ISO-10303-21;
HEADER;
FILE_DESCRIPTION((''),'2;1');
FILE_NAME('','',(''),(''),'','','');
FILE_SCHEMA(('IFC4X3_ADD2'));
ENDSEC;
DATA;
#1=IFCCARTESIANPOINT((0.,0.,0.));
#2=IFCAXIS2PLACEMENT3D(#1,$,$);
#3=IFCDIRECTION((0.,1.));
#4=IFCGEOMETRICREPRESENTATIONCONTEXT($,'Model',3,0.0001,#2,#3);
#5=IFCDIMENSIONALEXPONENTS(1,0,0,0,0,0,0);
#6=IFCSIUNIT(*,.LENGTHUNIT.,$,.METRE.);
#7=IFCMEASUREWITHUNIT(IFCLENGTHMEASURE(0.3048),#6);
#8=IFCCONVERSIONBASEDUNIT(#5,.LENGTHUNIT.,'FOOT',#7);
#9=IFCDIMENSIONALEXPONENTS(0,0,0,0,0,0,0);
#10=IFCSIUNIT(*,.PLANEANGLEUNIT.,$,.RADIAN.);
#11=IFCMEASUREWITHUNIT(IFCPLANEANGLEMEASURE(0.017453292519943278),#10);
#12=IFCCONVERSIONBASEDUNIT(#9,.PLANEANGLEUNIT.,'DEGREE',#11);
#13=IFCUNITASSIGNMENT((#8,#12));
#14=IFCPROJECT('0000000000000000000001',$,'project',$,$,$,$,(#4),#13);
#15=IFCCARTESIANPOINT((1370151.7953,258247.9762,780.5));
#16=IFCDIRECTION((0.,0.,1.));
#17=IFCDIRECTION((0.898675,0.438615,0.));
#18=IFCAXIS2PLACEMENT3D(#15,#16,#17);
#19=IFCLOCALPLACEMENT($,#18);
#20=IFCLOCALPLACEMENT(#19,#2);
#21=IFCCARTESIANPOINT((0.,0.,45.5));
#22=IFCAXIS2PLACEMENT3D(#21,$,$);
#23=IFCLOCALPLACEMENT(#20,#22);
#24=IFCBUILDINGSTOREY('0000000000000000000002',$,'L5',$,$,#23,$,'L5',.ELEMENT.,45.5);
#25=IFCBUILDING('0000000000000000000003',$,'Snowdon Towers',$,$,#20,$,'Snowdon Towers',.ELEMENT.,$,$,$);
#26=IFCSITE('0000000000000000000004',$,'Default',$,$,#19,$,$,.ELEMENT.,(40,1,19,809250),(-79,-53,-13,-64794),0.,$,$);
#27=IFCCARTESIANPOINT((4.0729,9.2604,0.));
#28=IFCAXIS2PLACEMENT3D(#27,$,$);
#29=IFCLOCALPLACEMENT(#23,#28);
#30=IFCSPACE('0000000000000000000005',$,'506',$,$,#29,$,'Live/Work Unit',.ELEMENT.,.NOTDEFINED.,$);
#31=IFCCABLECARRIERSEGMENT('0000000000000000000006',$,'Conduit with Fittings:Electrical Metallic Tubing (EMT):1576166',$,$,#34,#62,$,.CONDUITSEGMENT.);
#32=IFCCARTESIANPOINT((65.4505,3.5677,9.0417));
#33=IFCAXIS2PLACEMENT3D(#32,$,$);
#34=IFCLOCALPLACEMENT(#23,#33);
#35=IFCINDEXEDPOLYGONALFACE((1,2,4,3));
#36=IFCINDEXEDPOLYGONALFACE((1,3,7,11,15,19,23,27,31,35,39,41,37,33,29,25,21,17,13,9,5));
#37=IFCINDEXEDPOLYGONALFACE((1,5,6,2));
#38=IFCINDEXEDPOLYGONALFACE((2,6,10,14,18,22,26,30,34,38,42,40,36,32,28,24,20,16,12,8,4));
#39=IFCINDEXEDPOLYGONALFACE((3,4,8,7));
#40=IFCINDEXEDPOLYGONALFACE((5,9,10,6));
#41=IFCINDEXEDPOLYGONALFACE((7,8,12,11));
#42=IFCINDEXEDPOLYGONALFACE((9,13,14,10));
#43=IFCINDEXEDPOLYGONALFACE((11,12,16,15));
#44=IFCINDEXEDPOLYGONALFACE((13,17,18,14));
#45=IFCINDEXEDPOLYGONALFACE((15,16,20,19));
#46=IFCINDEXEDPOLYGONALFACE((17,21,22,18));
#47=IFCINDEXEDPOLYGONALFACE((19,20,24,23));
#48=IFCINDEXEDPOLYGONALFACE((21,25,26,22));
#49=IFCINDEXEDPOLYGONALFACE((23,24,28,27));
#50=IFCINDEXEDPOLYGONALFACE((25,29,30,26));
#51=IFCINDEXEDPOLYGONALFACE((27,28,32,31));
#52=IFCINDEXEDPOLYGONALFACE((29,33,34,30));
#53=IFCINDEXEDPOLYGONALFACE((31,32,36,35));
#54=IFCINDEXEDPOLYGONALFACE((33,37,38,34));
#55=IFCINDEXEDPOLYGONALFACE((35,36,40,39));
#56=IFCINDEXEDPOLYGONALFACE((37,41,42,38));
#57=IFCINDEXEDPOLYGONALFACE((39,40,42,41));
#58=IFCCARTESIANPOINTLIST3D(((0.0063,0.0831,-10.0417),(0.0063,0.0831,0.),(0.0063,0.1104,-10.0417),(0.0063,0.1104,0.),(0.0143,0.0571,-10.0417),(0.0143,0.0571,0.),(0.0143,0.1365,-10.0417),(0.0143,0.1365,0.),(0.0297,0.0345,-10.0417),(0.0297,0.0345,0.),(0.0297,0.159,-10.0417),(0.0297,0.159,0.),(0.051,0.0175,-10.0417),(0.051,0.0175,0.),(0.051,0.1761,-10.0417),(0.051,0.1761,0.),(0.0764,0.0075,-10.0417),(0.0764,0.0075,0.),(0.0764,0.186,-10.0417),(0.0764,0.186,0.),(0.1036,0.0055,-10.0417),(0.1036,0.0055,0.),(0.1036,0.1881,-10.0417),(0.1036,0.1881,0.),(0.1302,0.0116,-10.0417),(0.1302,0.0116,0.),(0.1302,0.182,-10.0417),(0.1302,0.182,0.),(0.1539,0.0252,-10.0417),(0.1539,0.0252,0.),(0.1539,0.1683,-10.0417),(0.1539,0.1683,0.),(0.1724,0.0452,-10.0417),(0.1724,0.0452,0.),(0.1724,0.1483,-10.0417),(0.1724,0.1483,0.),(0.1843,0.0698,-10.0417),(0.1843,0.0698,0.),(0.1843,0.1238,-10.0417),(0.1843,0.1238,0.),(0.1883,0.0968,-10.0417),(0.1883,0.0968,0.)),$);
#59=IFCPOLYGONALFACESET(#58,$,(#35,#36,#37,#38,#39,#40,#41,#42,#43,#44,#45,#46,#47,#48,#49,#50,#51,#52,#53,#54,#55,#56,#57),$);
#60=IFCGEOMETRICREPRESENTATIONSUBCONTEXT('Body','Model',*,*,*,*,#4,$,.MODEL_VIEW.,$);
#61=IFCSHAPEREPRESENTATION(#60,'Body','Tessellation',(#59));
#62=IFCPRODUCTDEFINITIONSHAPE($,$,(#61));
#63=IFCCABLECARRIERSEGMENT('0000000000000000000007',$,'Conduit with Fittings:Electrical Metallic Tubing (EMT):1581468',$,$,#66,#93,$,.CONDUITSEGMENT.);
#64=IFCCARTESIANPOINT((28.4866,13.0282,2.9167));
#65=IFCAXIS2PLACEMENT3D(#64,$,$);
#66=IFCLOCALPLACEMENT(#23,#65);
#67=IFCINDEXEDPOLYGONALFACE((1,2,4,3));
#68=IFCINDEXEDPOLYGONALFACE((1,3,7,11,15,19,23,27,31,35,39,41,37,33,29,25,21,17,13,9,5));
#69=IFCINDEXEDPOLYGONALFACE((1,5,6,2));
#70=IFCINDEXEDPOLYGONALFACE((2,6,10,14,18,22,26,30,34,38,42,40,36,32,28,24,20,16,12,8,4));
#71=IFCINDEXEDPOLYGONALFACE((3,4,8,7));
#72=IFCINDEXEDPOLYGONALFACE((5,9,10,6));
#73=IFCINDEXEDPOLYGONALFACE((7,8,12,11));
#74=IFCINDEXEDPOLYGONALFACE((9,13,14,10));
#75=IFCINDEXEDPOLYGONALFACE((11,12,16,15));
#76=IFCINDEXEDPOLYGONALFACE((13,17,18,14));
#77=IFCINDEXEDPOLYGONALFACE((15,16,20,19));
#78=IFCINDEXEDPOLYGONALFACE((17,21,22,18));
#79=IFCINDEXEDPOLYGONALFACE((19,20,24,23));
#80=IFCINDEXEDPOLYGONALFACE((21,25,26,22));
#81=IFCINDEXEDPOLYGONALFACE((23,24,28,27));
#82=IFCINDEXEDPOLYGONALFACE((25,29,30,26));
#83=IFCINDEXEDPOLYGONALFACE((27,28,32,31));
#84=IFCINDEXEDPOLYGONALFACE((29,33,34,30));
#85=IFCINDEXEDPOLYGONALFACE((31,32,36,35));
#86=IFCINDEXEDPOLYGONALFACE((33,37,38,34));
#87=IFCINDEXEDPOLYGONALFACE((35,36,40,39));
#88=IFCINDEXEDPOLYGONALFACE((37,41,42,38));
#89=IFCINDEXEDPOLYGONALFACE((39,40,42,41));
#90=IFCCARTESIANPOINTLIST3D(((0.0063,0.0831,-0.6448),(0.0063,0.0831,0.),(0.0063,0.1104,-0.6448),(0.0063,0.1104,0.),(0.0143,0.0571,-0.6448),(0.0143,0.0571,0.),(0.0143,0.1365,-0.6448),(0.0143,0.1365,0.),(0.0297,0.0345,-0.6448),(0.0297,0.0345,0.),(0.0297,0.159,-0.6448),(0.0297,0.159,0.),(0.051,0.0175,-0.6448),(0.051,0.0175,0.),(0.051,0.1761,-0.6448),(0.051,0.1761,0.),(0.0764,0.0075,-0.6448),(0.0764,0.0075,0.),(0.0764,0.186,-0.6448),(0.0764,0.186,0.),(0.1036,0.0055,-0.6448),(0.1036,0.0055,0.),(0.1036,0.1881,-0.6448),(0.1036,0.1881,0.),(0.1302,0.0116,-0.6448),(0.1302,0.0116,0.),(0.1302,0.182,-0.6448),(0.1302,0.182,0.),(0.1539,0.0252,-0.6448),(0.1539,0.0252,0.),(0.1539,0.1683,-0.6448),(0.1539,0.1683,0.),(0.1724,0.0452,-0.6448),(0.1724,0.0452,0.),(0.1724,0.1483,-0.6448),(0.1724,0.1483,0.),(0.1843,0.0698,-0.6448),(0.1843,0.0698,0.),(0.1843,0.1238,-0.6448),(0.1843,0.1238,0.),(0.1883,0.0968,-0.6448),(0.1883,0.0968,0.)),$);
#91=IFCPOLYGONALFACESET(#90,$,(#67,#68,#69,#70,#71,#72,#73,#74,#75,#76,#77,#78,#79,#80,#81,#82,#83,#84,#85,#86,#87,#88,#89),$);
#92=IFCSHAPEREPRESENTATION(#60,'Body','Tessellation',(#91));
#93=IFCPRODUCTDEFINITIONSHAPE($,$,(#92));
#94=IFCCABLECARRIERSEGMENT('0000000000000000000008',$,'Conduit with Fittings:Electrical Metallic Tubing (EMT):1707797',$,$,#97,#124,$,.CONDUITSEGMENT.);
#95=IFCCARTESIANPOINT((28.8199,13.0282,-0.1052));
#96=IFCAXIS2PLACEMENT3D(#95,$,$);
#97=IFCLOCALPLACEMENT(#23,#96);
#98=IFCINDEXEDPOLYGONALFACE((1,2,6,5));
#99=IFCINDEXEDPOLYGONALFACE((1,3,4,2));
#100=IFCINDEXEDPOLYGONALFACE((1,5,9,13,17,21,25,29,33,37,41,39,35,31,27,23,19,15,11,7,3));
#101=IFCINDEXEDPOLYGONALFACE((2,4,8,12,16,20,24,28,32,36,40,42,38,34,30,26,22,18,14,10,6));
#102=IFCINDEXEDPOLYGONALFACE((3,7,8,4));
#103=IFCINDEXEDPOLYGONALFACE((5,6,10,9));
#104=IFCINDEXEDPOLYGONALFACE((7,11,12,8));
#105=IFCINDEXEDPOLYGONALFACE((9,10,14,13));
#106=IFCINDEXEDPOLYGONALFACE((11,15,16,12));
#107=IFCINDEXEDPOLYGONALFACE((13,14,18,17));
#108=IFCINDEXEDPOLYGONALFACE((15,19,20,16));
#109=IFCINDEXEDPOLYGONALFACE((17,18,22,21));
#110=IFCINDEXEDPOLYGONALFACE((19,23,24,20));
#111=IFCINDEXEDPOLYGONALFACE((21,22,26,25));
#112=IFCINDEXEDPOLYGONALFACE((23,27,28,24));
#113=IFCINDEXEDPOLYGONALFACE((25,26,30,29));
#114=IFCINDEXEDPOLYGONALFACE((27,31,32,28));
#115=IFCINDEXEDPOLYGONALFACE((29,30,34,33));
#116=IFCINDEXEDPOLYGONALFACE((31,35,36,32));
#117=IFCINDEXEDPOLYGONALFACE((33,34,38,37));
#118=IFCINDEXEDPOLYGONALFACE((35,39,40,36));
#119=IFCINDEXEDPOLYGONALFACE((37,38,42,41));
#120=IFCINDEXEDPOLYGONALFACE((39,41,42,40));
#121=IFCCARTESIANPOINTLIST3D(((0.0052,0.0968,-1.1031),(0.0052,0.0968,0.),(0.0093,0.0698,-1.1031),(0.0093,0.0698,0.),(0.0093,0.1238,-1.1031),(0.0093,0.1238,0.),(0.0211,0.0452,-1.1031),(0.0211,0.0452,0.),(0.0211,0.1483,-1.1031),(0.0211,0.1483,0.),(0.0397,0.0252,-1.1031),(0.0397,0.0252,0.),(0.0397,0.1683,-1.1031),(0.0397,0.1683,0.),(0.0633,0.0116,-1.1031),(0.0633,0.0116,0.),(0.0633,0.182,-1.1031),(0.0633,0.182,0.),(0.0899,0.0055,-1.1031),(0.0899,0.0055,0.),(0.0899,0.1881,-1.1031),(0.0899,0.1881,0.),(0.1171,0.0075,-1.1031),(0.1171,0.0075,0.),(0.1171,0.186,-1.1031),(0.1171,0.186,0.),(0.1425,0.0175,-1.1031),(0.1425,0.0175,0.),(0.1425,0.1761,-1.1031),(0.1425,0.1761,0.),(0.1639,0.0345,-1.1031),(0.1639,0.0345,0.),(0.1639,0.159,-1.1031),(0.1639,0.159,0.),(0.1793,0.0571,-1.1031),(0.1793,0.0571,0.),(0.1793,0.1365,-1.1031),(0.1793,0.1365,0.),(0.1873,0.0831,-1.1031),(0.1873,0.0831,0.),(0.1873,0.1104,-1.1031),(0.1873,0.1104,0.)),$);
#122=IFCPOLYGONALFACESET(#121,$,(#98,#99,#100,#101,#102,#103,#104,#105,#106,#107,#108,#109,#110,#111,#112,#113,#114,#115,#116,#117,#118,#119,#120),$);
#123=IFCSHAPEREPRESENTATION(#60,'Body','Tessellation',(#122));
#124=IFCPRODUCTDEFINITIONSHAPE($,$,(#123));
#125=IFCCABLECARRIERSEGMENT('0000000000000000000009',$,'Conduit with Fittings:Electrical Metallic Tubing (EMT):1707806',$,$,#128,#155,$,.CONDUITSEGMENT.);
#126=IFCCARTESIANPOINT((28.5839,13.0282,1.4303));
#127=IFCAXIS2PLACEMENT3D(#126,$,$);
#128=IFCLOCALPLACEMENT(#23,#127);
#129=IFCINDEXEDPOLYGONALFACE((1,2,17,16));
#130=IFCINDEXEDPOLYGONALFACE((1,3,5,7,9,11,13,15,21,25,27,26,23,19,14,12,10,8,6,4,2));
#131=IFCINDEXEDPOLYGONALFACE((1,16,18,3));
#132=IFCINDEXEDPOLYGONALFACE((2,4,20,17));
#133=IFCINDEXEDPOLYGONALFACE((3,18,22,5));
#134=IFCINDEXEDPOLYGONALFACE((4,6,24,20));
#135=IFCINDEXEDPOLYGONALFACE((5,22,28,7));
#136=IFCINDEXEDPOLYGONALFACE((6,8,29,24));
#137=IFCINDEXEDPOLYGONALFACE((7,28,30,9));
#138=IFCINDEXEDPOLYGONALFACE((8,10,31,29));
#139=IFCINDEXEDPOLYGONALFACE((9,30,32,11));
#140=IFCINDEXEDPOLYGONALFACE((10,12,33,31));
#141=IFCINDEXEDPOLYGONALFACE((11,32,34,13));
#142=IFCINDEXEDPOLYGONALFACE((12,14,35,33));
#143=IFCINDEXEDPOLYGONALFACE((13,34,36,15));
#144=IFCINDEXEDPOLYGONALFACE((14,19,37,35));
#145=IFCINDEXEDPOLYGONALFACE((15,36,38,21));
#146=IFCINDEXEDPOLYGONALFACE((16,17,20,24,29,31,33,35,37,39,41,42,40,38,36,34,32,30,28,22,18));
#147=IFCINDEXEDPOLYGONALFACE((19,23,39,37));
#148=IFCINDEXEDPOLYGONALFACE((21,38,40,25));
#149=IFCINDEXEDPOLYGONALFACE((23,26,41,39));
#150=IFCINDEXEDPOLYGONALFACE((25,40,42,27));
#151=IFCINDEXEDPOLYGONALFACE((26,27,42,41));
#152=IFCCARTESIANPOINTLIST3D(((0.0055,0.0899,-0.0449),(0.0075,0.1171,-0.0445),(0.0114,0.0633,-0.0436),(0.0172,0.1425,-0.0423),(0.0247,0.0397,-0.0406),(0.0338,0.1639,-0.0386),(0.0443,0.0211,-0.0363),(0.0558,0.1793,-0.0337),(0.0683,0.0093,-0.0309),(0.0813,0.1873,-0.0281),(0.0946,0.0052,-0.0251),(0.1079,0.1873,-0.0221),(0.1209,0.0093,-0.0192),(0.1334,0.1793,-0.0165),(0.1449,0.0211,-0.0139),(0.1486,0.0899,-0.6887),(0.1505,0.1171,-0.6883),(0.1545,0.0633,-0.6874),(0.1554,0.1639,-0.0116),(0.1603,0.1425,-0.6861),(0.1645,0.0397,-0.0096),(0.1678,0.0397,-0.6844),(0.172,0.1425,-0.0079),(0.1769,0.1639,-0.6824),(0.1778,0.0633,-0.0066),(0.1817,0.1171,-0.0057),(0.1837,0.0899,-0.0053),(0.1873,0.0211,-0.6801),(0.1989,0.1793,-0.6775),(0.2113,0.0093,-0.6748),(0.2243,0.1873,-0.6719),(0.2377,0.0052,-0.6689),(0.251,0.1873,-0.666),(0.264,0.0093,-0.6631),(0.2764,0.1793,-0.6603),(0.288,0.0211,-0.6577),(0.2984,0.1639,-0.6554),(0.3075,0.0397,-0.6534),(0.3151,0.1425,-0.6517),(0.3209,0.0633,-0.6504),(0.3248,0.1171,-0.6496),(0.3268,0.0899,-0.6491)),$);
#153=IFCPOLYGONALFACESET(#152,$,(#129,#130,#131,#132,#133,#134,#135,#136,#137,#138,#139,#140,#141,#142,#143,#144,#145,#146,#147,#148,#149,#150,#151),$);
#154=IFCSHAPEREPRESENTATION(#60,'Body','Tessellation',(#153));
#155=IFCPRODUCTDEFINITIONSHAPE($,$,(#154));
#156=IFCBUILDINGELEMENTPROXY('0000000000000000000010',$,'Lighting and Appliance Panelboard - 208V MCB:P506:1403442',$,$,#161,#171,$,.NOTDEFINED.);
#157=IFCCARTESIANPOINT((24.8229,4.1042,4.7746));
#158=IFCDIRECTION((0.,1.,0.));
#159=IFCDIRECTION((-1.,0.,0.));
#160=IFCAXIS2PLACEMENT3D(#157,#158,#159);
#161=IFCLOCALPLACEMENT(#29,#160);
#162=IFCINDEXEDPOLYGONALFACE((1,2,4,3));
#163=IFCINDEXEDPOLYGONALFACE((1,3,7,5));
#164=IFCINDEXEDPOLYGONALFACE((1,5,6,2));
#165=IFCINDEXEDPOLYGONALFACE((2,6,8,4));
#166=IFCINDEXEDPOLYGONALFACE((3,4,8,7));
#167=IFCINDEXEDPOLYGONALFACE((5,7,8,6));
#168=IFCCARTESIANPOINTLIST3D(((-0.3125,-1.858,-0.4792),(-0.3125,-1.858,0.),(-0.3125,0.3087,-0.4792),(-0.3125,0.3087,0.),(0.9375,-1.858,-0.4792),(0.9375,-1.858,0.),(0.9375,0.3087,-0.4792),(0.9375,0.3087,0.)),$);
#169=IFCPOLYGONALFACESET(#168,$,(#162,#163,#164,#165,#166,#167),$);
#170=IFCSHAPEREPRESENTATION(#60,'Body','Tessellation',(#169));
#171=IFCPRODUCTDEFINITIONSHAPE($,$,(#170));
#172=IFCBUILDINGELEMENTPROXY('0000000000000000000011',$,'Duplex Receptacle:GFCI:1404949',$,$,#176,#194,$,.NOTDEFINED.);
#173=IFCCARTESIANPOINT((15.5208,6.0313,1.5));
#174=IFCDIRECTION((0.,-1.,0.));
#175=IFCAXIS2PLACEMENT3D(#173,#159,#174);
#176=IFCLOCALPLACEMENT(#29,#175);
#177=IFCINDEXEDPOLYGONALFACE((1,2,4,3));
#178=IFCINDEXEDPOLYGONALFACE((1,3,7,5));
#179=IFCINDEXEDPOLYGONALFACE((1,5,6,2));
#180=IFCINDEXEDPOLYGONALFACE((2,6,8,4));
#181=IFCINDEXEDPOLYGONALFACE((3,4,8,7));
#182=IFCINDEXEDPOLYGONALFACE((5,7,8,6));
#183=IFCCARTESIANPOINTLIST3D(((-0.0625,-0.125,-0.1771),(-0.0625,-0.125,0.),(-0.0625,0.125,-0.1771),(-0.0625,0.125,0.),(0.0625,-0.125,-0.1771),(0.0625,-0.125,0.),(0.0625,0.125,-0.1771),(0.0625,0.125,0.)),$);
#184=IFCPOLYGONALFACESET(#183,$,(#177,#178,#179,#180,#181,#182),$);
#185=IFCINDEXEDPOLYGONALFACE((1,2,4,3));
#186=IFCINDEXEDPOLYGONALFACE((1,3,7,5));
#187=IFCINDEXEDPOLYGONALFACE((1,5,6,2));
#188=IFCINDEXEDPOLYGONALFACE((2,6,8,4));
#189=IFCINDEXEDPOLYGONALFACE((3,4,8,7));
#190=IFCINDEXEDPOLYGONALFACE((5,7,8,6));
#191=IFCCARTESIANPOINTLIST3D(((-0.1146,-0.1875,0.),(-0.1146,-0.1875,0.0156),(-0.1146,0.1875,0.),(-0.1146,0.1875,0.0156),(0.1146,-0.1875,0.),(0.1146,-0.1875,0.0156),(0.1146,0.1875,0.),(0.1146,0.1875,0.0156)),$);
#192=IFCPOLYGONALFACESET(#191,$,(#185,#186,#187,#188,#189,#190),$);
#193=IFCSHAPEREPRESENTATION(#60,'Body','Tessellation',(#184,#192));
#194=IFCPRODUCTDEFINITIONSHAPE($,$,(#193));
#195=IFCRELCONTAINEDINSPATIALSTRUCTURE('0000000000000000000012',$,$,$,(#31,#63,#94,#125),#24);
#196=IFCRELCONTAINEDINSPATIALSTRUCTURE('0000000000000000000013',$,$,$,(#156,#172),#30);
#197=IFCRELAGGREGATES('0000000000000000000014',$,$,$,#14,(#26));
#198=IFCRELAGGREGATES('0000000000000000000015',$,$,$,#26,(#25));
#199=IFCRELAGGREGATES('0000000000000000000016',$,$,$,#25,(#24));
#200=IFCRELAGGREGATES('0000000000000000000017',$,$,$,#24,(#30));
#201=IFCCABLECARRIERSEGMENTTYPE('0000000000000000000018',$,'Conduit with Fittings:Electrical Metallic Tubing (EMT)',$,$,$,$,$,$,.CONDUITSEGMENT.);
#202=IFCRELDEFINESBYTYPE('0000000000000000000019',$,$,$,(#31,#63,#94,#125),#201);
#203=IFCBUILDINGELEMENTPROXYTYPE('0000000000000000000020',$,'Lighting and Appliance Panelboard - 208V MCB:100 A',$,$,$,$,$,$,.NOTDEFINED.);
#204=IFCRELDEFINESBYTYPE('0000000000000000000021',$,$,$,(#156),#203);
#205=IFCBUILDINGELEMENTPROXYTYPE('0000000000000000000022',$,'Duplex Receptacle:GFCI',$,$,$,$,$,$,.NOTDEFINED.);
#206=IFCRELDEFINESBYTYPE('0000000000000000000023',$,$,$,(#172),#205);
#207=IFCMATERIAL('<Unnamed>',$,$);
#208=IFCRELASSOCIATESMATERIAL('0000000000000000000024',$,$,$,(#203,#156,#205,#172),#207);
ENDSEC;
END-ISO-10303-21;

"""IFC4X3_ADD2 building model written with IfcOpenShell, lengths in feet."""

from ifc_helpers import new_model, entity, si_unit, converted_unit, direction, frame, frame_2d, origin, origin_2d_with_axis, place, context, subcontext, project, spatial, rectangle, circle, extrude, source, transform, mapped, material, type_object, type_shapes, element, save


model = new_model("IFC4X3_ADD2")

# Units and contexts
model_context = context("Model", 3, precision=0.0001, world=origin(), true_north=direction((0.0, 1.0)))
body_context = subcontext(model_context, "Body", "Model", "MODEL_VIEW")
ifc_project = project(units=[converted_unit("LENGTHUNIT", "FOOT", entity("IfcLengthMeasure", 0.3048), si_unit("LENGTHUNIT", "METRE"), dimensions=[1, 0, 0, 0, 0, 0, 0]), converted_unit("PLANEANGLEUNIT", "DEGREE", entity("IfcPlaneAngleMeasure", 0.017453292519943278), si_unit("PLANEANGLEUNIT", "RADIAN"), dimensions=[0, 0, 0, 0, 0, 0, 0])], contexts=[model_context])

# Site, building, storey, space
site_placement = place(None, frame((1370151.7953, 258247.9762, 780.5), z_axis=(0.0, 0.0, 1.0), x_axis=(0.898675, 0.438615, 0.0)))
site = spatial("IfcSite", under=ifc_project, at=site_placement, Name="Default", CompositionType="ELEMENT", RefLatitude=(40, 1, 19, 809250), RefLongitude=(-79, -53, -13, -64794), RefElevation=0.0)
building_placement = place(site_placement, origin())
building = spatial("IfcBuilding", under=site, at=building_placement, Name="Snowdon Towers", LongName="Snowdon Towers", CompositionType="ELEMENT")
storey_placement = place(building_placement, frame((0.0, 0.0, 45.5)))
storey = spatial("IfcBuildingStorey", under=building, at=storey_placement, Name="L5", LongName="L5", CompositionType="ELEMENT", Elevation=45.5)
space_1_placement = place(storey_placement, frame((4.0729, 9.2604, 0.0)))
space_1 = spatial("IfcSpace", under=storey, at=space_1_placement, Name="506", LongName="Live/Work Unit", CompositionType="ELEMENT", PredefinedType="NOTDEFINED")

# Shared definitions
ifc_material_1 = material(Name="<Unnamed>")

# Cable carrier segments
cable_carrier_segment_type = type_object("IfcCableCarrierSegmentType", Name="Conduit with Fittings:Electrical Metallic Tubing (EMT)", PredefinedType="CONDUITSEGMENT")
cable_carrier_segment_1_placement = place(storey_placement, frame((65.4505, 3.5677, 9.0417)))
element("IfcCableCarrierSegment", 1, at=cable_carrier_segment_1_placement, inside=storey, type_object=cable_carrier_segment_type, Name="Conduit with Fittings:Electrical Metallic Tubing (EMT):1576166", PredefinedType="CONDUITSEGMENT", context=body_context, shape_type="SweptSolid", body=[
    extrude(circle(Radius=0.0915, at=frame_2d((0.0, 0.0), x_axis=(1.0, 0.0))), frame((0.0968, 0.0968, -10.0417)), (0.0, 0.0, 1.0), 10.0417),
])
cable_carrier_segment_2_placement = place(storey_placement, frame((28.4866, 13.0282, 2.9167)))
element("IfcCableCarrierSegment", 2, at=cable_carrier_segment_2_placement, inside=storey, type_object=cable_carrier_segment_type, Name="Conduit with Fittings:Electrical Metallic Tubing (EMT):1581468", PredefinedType="CONDUITSEGMENT", context=body_context, shape_type="SweptSolid", body=[
    extrude(circle(Radius=0.0915, at=frame_2d((0.0, 0.0), x_axis=(1.0, 0.0))), frame((0.0968, 0.0968, -0.6448)), (0.0, 0.0, 1.0), 0.6448),
])
cable_carrier_segment_3_placement = place(storey_placement, frame((28.8199, 13.0282, -0.1052)))
element("IfcCableCarrierSegment", 3, at=cable_carrier_segment_3_placement, inside=storey, type_object=cable_carrier_segment_type, Name="Conduit with Fittings:Electrical Metallic Tubing (EMT):1707797", PredefinedType="CONDUITSEGMENT", context=body_context, shape_type="SweptSolid", body=[
    extrude(circle(Radius=0.0915, at=frame_2d((0.0, 0.0), x_axis=(1.0, 0.0))), frame((0.0968, 0.0968, -1.1031), z_axis=(0.0, 0.0, 1.0), x_axis=(-1.0, 0.0, 0.0)), (0.0, 0.0, 1.0), 1.1031),
])
cable_carrier_segment_4_placement = place(storey_placement, frame((28.5839, 13.0282, 1.4303)))
element("IfcCableCarrierSegment", 4, at=cable_carrier_segment_4_placement, inside=storey, type_object=cable_carrier_segment_type, Name="Conduit with Fittings:Electrical Metallic Tubing (EMT):1707806", PredefinedType="CONDUITSEGMENT", context=body_context, shape_type="SweptSolid", body=[
    extrude(circle(Radius=0.0915, at=frame_2d((0.0, 0.0), x_axis=(1.0, 0.0))), frame((0.0946, 0.0968, -0.0251), z_axis=(0.21693, 0.0, -0.976187), x_axis=(0.0, -1.0, 0.0)), (0.0, 0.0, 1.0), 0.6595),
])

# Building element proxies
building_element_proxy_type_1 = type_object("IfcBuildingElementProxyType", Name="Lighting and Appliance Panelboard - 208V MCB:100 A", PredefinedType="NOTDEFINED", material=ifc_material_1)
shared_shape_1 = source(origin(), body_context, "Body", "SweptSolid", [
    extrude(rectangle(XDim=1.25, YDim=2.1667, at=origin_2d_with_axis()), frame((0.3125, -0.7746, -0.4792), z_axis=(0.0, 0.0, 1.0), x_axis=(-1.0, 0.0, 0.0)), (0.0, 0.0, 1.0), 0.4792),
])
type_shapes(building_element_proxy_type_1, [shared_shape_1])
proxy_1_placement = place(space_1_placement, frame((24.8229, 4.1042, 4.7746), z_axis=(0.0, 1.0, 0.0), x_axis=(-1.0, 0.0, 0.0)))
element("IfcBuildingElementProxy", 5, at=proxy_1_placement, inside=space_1, type_object=building_element_proxy_type_1, material=ifc_material_1, Name="Lighting and Appliance Panelboard - 208V MCB:P506:1403442", PredefinedType="NOTDEFINED", context=body_context, shape_type="MappedRepresentation", body=[
    mapped(shared_shape_1, transform((0.0, 0.0, 0.0), scale=1.0)),
])
building_element_proxy_type_2 = type_object("IfcBuildingElementProxyType", Name="Duplex Receptacle:GFCI", PredefinedType="NOTDEFINED", material=ifc_material_1)
shared_shape_2 = source(origin(), body_context, "Body", "SweptSolid", [
    extrude(rectangle(XDim=0.125, YDim=0.25, at=origin_2d_with_axis()), frame((0.0, 0.0, -0.1771), z_axis=(0.0, 0.0, 1.0), x_axis=(-1.0, 0.0, 0.0)), (0.0, 0.0, 1.0), 0.1771),
    extrude(rectangle(XDim=0.2292, YDim=0.375, at=frame_2d((0.0, 0.0), x_axis=(1.0, 0.0))), frame((0.0, 0.0, 0.0), z_axis=(0.0, 0.0, 1.0), x_axis=(-1.0, 0.0, 0.0)), (0.0, 0.0, 1.0), 0.0156),
])
type_shapes(building_element_proxy_type_2, [shared_shape_2])
proxy_2_placement = place(space_1_placement, frame((15.5208, 6.0313, 1.5), z_axis=(-1.0, 0.0, 0.0), x_axis=(0.0, -1.0, 0.0)))
element("IfcBuildingElementProxy", 6, at=proxy_2_placement, inside=space_1, type_object=building_element_proxy_type_2, material=ifc_material_1, Name="Duplex Receptacle:GFCI:1404949", PredefinedType="NOTDEFINED", context=body_context, shape_type="MappedRepresentation", body=[
    mapped(shared_shape_2, transform((0.0, 0.0, 0.0), scale=1.0)),
])

save(model, "model.ifc")
